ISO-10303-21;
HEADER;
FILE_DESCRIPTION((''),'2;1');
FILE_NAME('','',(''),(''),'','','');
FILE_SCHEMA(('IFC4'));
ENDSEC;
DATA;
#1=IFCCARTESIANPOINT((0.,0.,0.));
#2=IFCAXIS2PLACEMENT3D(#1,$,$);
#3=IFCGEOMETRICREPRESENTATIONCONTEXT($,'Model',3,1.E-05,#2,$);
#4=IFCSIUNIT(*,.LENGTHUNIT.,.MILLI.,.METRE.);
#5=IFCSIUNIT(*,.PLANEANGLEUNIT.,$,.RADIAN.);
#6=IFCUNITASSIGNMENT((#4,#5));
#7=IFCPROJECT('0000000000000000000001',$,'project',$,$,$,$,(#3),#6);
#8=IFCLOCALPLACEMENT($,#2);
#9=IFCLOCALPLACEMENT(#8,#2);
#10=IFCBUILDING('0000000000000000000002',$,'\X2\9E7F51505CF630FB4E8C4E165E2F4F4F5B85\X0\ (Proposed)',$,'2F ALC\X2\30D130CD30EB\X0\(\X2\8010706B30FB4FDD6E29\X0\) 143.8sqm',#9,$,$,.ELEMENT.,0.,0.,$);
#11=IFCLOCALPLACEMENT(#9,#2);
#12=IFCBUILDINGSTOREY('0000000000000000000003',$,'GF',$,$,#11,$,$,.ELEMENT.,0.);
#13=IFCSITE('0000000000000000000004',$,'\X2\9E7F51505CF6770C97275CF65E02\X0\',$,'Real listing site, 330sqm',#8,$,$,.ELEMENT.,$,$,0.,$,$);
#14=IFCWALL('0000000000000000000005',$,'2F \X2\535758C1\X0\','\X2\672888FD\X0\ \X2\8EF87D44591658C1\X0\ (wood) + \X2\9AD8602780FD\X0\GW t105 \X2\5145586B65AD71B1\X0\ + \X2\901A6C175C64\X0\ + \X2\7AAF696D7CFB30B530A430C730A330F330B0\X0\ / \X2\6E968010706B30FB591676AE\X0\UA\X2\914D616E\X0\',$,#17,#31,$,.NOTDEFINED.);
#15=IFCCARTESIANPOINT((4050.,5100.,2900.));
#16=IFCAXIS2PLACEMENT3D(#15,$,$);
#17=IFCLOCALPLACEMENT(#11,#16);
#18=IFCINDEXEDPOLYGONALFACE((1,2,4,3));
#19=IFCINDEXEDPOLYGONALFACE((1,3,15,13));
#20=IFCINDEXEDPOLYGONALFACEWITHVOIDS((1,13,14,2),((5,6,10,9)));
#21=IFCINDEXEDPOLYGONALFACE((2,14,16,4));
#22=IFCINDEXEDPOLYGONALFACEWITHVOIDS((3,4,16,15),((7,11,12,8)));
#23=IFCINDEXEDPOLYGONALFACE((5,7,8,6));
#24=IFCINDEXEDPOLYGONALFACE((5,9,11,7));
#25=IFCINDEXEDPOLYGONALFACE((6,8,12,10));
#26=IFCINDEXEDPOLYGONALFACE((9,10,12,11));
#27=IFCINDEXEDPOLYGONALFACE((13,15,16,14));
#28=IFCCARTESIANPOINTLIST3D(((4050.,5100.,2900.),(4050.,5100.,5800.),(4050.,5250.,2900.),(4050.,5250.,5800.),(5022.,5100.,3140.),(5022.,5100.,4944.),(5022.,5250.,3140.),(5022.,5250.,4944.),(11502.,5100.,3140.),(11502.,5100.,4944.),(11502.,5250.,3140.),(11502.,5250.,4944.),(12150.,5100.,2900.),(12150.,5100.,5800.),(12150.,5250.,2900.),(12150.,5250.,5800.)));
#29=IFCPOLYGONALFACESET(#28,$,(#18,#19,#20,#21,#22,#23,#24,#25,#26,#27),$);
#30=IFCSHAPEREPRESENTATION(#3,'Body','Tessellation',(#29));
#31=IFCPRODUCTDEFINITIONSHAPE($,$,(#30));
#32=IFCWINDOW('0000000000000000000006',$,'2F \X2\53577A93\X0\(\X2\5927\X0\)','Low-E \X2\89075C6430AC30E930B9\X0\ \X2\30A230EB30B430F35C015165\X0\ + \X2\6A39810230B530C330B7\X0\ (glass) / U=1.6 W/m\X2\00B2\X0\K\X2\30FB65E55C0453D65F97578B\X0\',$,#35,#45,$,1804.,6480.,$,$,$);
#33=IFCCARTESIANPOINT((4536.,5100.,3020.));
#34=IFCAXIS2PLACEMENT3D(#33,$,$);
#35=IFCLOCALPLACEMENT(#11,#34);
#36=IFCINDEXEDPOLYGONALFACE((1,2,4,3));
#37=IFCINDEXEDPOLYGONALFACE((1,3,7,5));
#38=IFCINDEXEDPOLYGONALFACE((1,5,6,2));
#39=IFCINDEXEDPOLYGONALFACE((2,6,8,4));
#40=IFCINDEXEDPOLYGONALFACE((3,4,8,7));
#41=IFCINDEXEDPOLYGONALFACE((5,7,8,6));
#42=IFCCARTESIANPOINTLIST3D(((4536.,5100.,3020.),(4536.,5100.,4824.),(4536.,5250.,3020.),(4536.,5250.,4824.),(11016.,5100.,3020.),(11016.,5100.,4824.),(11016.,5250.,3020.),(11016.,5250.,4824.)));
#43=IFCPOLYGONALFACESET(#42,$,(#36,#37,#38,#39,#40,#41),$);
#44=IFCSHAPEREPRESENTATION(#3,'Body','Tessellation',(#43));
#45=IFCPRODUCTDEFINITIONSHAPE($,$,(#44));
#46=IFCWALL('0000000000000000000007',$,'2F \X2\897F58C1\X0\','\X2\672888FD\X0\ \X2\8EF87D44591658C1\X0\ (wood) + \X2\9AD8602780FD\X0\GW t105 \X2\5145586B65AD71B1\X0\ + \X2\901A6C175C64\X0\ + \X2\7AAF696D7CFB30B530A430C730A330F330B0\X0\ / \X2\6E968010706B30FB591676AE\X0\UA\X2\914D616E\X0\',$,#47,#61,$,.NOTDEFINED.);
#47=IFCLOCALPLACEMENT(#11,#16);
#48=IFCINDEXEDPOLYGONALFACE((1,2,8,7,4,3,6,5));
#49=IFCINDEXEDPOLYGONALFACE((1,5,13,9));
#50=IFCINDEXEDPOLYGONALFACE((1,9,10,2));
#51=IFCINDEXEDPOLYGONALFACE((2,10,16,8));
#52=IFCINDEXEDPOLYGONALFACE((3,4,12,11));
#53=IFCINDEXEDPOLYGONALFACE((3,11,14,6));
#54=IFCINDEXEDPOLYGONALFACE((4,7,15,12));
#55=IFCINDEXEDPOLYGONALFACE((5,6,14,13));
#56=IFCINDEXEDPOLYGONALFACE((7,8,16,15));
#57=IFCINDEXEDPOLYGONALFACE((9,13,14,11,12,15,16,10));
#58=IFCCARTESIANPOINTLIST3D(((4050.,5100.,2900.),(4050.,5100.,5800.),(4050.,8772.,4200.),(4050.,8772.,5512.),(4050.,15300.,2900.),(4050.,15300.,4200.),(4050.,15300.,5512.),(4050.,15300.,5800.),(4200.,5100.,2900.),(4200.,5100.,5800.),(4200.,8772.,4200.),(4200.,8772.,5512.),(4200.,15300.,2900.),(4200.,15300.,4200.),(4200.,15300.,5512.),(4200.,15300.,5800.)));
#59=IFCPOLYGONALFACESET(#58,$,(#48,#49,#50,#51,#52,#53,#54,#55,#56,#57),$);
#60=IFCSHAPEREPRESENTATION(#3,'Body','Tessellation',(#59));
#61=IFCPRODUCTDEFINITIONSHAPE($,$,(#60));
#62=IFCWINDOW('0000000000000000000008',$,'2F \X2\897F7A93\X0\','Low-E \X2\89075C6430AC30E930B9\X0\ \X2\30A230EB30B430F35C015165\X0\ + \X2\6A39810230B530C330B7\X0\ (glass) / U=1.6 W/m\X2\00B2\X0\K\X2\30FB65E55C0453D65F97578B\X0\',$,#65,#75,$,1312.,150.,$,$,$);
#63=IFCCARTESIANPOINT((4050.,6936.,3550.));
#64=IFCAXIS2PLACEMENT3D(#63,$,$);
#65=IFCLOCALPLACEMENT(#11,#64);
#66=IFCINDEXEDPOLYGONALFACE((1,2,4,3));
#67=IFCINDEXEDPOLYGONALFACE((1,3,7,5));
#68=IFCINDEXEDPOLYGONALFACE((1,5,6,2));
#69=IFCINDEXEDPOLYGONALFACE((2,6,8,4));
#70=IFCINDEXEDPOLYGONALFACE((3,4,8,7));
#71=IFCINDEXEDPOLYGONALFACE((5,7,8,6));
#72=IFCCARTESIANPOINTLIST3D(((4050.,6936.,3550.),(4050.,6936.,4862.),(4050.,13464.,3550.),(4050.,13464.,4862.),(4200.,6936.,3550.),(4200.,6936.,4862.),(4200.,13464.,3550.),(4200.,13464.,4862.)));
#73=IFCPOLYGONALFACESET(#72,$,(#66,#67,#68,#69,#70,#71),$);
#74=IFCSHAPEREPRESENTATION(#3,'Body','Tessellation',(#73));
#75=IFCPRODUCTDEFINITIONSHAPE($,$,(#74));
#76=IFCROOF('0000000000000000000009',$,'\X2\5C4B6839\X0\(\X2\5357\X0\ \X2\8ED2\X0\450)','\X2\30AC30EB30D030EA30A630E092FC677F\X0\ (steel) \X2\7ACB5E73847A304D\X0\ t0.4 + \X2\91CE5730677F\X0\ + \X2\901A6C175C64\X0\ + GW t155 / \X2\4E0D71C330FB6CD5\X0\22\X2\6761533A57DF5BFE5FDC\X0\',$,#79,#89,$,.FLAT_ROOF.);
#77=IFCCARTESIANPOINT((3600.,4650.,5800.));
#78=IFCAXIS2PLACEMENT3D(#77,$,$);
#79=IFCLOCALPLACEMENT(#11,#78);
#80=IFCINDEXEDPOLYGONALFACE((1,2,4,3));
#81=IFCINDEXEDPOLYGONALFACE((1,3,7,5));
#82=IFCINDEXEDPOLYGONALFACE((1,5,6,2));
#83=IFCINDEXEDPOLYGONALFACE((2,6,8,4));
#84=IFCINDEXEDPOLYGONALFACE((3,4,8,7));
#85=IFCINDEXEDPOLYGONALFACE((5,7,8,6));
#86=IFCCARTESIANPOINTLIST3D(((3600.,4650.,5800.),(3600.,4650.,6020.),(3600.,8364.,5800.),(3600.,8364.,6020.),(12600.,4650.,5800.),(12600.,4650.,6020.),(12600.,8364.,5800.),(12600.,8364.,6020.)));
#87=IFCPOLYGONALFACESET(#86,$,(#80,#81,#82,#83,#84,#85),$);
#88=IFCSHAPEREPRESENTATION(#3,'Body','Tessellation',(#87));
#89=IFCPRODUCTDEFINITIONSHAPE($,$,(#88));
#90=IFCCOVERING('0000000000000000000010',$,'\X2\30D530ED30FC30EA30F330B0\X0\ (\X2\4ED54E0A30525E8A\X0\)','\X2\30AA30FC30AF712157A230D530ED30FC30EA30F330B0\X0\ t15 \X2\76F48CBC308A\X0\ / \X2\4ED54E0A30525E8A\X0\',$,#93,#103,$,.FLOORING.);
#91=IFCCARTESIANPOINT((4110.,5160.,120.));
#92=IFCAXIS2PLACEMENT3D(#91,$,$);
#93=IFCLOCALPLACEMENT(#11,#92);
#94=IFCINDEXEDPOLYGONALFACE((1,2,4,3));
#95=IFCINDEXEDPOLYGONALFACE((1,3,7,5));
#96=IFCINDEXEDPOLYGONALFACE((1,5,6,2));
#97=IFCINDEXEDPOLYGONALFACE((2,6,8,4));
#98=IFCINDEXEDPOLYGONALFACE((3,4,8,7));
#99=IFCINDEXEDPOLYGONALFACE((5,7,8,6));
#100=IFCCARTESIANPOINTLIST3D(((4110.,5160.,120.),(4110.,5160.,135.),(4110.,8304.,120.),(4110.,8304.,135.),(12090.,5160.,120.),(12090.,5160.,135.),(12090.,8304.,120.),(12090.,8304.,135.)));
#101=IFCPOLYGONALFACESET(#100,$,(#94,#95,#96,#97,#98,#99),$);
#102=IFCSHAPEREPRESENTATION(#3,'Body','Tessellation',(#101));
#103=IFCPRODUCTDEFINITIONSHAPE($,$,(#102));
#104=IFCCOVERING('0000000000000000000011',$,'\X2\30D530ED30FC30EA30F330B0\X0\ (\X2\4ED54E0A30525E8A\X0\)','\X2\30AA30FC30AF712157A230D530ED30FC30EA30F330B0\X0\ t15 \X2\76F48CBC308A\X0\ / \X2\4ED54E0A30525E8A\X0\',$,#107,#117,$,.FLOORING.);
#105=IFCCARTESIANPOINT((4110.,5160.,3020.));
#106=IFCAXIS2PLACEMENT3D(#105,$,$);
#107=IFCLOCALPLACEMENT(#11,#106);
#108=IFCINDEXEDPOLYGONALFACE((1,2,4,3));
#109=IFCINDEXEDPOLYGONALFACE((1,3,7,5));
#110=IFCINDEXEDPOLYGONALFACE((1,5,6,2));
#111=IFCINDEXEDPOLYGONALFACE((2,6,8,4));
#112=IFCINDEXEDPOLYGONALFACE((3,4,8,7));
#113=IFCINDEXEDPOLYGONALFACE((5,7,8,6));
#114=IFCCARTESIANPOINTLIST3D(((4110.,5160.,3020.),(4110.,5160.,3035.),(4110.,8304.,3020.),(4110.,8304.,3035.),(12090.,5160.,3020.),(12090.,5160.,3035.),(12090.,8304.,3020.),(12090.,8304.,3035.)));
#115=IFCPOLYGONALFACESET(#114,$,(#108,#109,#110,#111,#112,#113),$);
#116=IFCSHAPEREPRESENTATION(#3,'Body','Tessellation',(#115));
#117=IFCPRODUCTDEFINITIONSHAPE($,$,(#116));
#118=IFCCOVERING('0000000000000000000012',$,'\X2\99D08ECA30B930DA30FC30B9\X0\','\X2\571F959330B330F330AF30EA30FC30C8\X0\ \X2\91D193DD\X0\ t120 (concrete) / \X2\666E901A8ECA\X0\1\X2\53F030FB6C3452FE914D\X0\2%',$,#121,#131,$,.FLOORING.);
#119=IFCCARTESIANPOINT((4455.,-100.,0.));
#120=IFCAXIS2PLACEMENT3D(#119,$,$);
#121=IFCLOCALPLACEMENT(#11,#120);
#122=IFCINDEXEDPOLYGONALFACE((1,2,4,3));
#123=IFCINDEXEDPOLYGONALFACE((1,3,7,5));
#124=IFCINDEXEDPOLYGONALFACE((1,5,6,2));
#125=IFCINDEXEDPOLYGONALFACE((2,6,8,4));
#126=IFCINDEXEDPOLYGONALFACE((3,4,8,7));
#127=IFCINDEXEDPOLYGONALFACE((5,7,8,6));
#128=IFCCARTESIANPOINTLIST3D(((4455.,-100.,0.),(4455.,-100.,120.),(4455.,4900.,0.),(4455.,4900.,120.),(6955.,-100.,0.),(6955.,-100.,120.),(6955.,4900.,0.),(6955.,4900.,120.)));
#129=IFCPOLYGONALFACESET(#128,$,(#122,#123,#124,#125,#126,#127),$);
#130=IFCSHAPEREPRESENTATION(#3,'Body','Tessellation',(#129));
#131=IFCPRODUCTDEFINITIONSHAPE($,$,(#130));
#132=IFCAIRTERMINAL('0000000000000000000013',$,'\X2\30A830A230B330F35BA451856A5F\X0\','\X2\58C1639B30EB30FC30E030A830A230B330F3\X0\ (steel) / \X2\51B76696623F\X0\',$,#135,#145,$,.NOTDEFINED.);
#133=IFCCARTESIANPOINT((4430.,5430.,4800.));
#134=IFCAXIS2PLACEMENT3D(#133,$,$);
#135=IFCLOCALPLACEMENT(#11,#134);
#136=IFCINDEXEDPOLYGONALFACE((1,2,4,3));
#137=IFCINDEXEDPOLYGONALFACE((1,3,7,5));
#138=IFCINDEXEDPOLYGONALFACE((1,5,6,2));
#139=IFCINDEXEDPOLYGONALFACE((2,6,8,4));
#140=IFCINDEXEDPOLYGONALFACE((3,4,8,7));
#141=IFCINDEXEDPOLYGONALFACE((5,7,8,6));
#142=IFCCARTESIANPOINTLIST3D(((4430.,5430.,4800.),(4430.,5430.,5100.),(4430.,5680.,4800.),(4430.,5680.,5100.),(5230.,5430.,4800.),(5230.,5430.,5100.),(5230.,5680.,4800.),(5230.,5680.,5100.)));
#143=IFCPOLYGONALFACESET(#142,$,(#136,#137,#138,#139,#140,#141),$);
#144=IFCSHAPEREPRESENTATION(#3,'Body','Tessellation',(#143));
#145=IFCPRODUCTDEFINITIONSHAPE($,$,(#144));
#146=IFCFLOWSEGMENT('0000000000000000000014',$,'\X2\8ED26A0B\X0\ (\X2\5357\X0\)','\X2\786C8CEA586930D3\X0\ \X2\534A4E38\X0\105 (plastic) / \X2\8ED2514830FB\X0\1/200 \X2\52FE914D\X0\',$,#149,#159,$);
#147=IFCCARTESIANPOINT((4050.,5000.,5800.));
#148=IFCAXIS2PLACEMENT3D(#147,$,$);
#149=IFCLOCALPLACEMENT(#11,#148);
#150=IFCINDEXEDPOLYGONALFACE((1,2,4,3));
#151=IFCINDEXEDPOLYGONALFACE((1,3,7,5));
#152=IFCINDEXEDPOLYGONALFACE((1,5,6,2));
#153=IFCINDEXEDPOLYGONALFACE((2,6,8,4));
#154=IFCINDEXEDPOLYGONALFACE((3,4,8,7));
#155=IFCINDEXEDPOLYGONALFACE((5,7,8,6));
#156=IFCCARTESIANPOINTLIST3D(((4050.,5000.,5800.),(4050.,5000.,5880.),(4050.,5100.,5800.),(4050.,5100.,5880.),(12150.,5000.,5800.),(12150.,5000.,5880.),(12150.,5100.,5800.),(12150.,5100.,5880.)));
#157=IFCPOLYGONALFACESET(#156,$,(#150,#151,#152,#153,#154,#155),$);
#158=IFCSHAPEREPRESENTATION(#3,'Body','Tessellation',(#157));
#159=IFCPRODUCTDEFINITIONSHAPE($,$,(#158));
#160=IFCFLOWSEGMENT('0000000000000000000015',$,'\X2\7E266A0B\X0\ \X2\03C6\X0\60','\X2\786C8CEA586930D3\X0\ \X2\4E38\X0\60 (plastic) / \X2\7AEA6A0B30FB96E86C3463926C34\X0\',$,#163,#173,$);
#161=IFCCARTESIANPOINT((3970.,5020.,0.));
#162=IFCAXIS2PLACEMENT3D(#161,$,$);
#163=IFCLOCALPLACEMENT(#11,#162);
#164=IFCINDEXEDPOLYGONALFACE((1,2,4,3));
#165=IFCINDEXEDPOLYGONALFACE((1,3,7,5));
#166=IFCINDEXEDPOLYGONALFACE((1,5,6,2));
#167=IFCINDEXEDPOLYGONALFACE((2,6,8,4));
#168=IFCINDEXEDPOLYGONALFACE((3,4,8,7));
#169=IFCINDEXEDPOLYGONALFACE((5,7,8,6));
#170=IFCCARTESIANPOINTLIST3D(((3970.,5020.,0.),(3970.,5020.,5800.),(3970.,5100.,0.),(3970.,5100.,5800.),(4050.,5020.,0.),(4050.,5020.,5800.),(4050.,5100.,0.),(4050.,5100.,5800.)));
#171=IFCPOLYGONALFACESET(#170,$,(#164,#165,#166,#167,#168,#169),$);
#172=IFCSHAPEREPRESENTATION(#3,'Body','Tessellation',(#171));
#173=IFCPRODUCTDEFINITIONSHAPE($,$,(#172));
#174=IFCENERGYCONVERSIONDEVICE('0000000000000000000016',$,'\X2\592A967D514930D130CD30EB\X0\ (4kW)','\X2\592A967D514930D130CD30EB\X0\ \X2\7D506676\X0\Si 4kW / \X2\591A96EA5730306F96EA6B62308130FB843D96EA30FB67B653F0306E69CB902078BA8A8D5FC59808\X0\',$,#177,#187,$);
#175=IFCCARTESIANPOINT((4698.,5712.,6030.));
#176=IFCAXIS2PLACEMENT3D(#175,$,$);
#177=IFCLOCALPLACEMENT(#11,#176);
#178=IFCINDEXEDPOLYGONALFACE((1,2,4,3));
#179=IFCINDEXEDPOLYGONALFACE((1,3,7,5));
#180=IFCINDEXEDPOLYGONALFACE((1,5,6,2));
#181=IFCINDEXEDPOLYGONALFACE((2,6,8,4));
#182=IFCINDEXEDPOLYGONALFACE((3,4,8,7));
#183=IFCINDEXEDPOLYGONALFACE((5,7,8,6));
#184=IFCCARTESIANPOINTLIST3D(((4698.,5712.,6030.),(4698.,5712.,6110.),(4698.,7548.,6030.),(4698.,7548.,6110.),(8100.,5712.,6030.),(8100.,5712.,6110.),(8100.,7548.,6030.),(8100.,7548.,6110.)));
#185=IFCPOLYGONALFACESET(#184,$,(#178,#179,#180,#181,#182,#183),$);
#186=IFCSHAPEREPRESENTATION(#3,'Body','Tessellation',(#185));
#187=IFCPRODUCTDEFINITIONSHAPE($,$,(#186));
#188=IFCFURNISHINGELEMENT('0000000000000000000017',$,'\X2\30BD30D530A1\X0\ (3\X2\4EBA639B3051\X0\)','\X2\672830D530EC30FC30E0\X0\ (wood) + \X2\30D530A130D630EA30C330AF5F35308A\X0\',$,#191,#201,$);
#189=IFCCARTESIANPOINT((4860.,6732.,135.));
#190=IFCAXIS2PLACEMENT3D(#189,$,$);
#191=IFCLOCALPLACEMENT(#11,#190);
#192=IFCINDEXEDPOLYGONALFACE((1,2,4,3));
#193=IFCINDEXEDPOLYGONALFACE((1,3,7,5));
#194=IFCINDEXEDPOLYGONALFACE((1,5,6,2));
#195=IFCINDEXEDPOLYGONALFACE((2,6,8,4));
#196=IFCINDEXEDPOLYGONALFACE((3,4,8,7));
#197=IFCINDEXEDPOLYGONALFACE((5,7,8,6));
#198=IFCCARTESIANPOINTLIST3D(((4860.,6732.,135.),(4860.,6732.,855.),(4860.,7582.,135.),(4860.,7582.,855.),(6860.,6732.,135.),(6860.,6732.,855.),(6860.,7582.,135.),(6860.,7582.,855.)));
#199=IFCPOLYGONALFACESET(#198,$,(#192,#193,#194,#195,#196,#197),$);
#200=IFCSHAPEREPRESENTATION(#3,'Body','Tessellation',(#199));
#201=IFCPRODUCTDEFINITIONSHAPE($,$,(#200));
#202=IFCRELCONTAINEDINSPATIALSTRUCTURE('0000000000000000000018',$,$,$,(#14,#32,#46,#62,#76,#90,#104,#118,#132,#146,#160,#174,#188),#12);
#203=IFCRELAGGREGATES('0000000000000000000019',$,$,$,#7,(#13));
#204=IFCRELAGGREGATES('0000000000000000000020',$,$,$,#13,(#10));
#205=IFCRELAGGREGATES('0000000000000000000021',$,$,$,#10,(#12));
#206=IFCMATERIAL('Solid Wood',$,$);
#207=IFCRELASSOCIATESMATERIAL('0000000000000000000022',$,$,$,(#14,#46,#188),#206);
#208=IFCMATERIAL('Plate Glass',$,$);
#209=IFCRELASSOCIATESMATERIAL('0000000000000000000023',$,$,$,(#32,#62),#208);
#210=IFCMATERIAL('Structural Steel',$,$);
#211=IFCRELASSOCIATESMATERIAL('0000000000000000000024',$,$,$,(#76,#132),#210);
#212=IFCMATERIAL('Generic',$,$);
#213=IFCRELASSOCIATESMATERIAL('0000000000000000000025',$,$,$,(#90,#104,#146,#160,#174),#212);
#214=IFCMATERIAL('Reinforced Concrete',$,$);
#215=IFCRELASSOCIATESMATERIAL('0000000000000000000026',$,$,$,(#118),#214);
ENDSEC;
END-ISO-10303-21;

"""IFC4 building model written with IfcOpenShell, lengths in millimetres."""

from ifc_helpers import new_model, si_unit, frame, frame_2d, origin, place, context, project, spatial, rectangle, extrude, material, element, fill, save


model = new_model("IFC4")

# Units and contexts
model_context = context("Model", 3, precision=1e-05, world=origin())
ifc_project = project(units=[si_unit("LENGTHUNIT", "METRE", prefix="MILLI"), si_unit("PLANEANGLEUNIT", "RADIAN")], contexts=[model_context])

# Site, building, storey
site_placement = place(None, origin())
site = spatial("IfcSite", under=ifc_project, at=site_placement, Name="鹿児島県霧島市", ObjectType="Real listing site, 330sqm", CompositionType="ELEMENT", RefElevation=0.0)
building_placement = place(site_placement, origin())
building = spatial("IfcBuilding", under=site, at=building_placement, Name="鹿児島・二世帯住宅 (Proposed)", ObjectType="2F ALCパネル(耐火・保温) 143.8sqm", CompositionType="ELEMENT", ElevationOfRefHeight=0.0, ElevationOfTerrain=0.0)
storey_placement = place(building_placement, origin())
storey = spatial("IfcBuildingStorey", under=building, at=storey_placement, Name="GF", CompositionType="ELEMENT", Elevation=0.0)

# Shared definitions
ifc_material_1 = material(Name="Solid Wood")

# Shared definitions
ifc_material_2 = material(Name="Reinforced Concrete")

# Shared definitions
ifc_material_3 = material(Name="Plate Glass")

# Walls, openings, windows
wall_1_placement = place(storey_placement, frame((4050.0, 5100.0, 2900.0)))
wall_1 = element("IfcWall", 1, at=wall_1_placement, inside=storey, material=ifc_material_1, Name="2F 南壁", Description="木製 軸組外壁 (wood) + 高性能GW t105 充填断熱 + 通気層 + 窯業系サイディング / 準耐火・外皮UA配慮", PredefinedType="NOTDEFINED", context=model_context, shape_type="SweptSolid", body=[
    extrude(rectangle(XDim=8100.0, YDim=150.0, at=frame_2d((4050.0, 75.0))), frame((4050.0, 5100.0, 2900.0)), (0.0, 0.0, 1.0), 2900.0),
])
opening_1_placement = place(storey_placement, frame((4536.0, 5100.0, 3020.0)))
opening_1 = element("IfcOpeningElement", 2, at=opening_1_placement, cuts=wall_1, PredefinedType="NOTDEFINED", context=model_context, shape_type="SweptSolid", body=[
    extrude(rectangle(XDim=6480.0, YDim=150.0, at=frame_2d((3240.0, 75.0))), frame((4536.0, 5100.0, 3020.0)), (0.0, 0.0, 1.0), 1804.0),
])
window_1_placement = place(storey_placement, frame((4536.0, 5100.0, 3020.0)))
window_1 = element("IfcWindow", 3, at=window_1_placement, inside=storey, material=ifc_material_3, Name="2F 南窓(大)", Description="Low-E 複層ガラス アルゴン封入 + 樹脂サッシ (glass) / U=1.6 W/m²K・日射取得型", OverallHeight=1804.0, OverallWidth=6480.0, context=model_context, shape_type="SweptSolid", body=[
    extrude(rectangle(XDim=6480.0, YDim=150.0, at=frame_2d((3240.0, 75.0))), frame((4536.0, 5100.0, 3020.0)), (0.0, 0.0, 1.0), 1804.0),
])
fill(opening_1, window_1)
wall_2_placement = place(storey_placement, frame((4050.0, 5100.0, 2900.0)))
wall_2 = element("IfcWall", 4, at=wall_2_placement, inside=storey, material=ifc_material_1, Name="2F 西壁", Description="木製 軸組外壁 (wood) + 高性能GW t105 充填断熱 + 通気層 + 窯業系サイディング / 準耐火・外皮UA配慮", PredefinedType="NOTDEFINED", context=model_context, shape_type="SweptSolid", body=[
    extrude(rectangle(XDim=150.0, YDim=10200.0, at=frame_2d((75.0, 5100.0))), frame((4050.0, 5100.0, 2900.0)), (0.0, 0.0, 1.0), 2900.0),
])
opening_2_placement = place(storey_placement, frame((4050.0, 6936.0, 3550.0)))
opening_2 = element("IfcOpeningElement", 5, at=opening_2_placement, cuts=wall_2, PredefinedType="NOTDEFINED", context=model_context, shape_type="SweptSolid", body=[
    extrude(rectangle(XDim=150.0, YDim=6528.0, at=frame_2d((75.0, 3264.0))), frame((4050.0, 6936.0, 3550.0)), (0.0, 0.0, 1.0), 1312.0),
])
window_2_placement = place(storey_placement, frame((4050.0, 6936.0, 3550.0)))
window_2 = element("IfcWindow", 6, at=window_2_placement, inside=storey, material=ifc_material_3, Name="2F 西窓", Description="Low-E 複層ガラス アルゴン封入 + 樹脂サッシ (glass) / U=1.6 W/m²K・日射取得型", OverallHeight=1312.0, OverallWidth=150.0, context=model_context, shape_type="SweptSolid", body=[
    extrude(rectangle(XDim=150.0, YDim=6528.0, at=frame_2d((75.0, 3264.0))), frame((4050.0, 6936.0, 3550.0)), (0.0, 0.0, 1.0), 1312.0),
])
fill(opening_2, window_2)

# Roof
ifc_material_4 = material(Name="Structural Steel")
for number, where, name in (
    (7, (3600.0, 4650.0, 5800.0), "屋根(南 軒450)"),
):
    element("IfcRoof", number, at=place(storey_placement, frame(where)), inside=storey, material=ifc_material_4, Name=name, Description="ガルバリウム鋼板 (steel) 立平葺き t0.4 + 野地板 + 通気層 + GW t155 / 不燃・法22条区域対応", PredefinedType="FLAT_ROOF", context=model_context, shape_type="SweptSolid", body=[
        extrude(rectangle(XDim=9000.0, YDim=3714.0, at=frame_2d((4500.0, 1857.0))), frame((3600.0, 4650.0, 5800.0)), (0.0, 0.0, 1.0), 220.0),
    ])

# Coverings
ifc_material_5 = material(Name="Generic")
covering_1_placement = place(storey_placement, frame((4110.0, 5160.0, 120.0)))
element("IfcCovering", 8, at=covering_1_placement, inside=storey, material=ifc_material_5, Name="フローリング (仕上げ床)", Description="オーク無垢フローリング t15 直貼り / 仕上げ床", PredefinedType="FLOORING", context=model_context, shape_type="SweptSolid", body=[
    extrude(rectangle(XDim=7980.0, YDim=3144.0, at=frame_2d((3990.0, 1572.0))), frame((4110.0, 5160.0, 120.0)), (0.0, 0.0, 1.0), 15.0),
])
covering_2_placement = place(storey_placement, frame((4110.0, 5160.0, 3020.0)))
element("IfcCovering", 9, at=covering_2_placement, inside=storey, material=ifc_material_5, Name="フローリング (仕上げ床)", Description="オーク無垢フローリング t15 直貼り / 仕上げ床", PredefinedType="FLOORING", context=model_context, shape_type="SweptSolid", body=[
    extrude(rectangle(XDim=7980.0, YDim=3144.0, at=frame_2d((3990.0, 1572.0))), frame((4110.0, 5160.0, 3020.0)), (0.0, 0.0, 1.0), 15.0),
])
covering_3_placement = place(storey_placement, frame((4455.0, -100.0, 0.0)))
element("IfcCovering", 10, at=covering_3_placement, inside=storey, material=ifc_material_2, Name="駐車スペース", Description="土間コンクリート 金鏝 t120 (concrete) / 普通車1台・水勾配2%", PredefinedType="FLOORING", context=model_context, shape_type="SweptSolid", body=[
    extrude(rectangle(XDim=2500.0, YDim=5000.0, at=frame_2d((1250.0, 2500.0))), frame((4455.0, -100.0, 0.0)), (0.0, 0.0, 1.0), 120.0),
])

# Air terminal
air_terminal_placement = place(storey_placement, frame((4430.0, 5430.0, 4800.0)))
element("IfcAirTerminal", 11, at=air_terminal_placement, inside=storey, material=ifc_material_4, Name="エアコン室内機", Description="壁掛ルームエアコン (steel) / 冷暖房", PredefinedType="NOTDEFINED", context=model_context, shape_type="SweptSolid", body=[
    extrude(rectangle(XDim=800.0, YDim=250.0, at=frame_2d((400.0, 125.0))), frame((4430.0, 5430.0, 4800.0)), (0.0, 0.0, 1.0), 300.0),
])

# Flow segments
flow_segment_1_placement = place(storey_placement, frame((4050.0, 5000.0, 5800.0)))
element("IfcFlowSegment", 12, at=flow_segment_1_placement, inside=storey, material=ifc_material_5, Name="軒樋 (南)", Description="硬質塩ビ 半丸105 (plastic) / 軒先・1/200 勾配", context=model_context, shape_type="SweptSolid", body=[
    extrude(rectangle(XDim=8100.0, YDim=100.0, at=frame_2d((4050.0, 50.0))), frame((4050.0, 5000.0, 5800.0)), (0.0, 0.0, 1.0), 80.0),
])
flow_segment_2_placement = place(storey_placement, frame((3970.0, 5020.0, 0.0)))
element("IfcFlowSegment", 13, at=flow_segment_2_placement, inside=storey, material=ifc_material_5, Name="縦樋 φ60", Description="硬質塩ビ 丸60 (plastic) / 竪樋・雨水排水", context=model_context, shape_type="SweptSolid", body=[
    extrude(rectangle(XDim=80.0, YDim=80.0, at=frame_2d((40.0, 40.0))), frame((3970.0, 5020.0, 0.0)), (0.0, 0.0, 1.0), 5800.0),
])

# Energy conversion device
energy_conversion_device_placement = place(storey_placement, frame((4698.0, 5712.0, 6030.0)))
element("IfcEnergyConversionDevice", 14, at=energy_conversion_device_placement, inside=storey, material=ifc_material_5, Name="太陽光パネル (4kW)", Description="太陽光パネル 結晶Si 4kW / 多雪地は雪止め・落雪・架台の構造確認必須", context=model_context, shape_type="SweptSolid", body=[
    extrude(rectangle(XDim=3402.0, YDim=1836.0, at=frame_2d((1701.0, 918.0))), frame((4698.0, 5712.0, 6030.0)), (0.0, 0.0, 1.0), 80.0),
])

# Furnishing element
furnishing_1_placement = place(storey_placement, frame((4860.0, 6732.0, 135.0)))
element("IfcFurnishingElement", 15, at=furnishing_1_placement, inside=storey, material=ifc_material_1, Name="ソファ (3人掛け)", Description="木フレーム (wood) + ファブリック張り", context=model_context, shape_type="SweptSolid", body=[
    extrude(rectangle(XDim=2000.0, YDim=850.0, at=frame_2d((1000.0, 425.0))), frame((4860.0, 6732.0, 135.0)), (0.0, 0.0, 1.0), 720.0),
])

save(model, "model.ifc")
